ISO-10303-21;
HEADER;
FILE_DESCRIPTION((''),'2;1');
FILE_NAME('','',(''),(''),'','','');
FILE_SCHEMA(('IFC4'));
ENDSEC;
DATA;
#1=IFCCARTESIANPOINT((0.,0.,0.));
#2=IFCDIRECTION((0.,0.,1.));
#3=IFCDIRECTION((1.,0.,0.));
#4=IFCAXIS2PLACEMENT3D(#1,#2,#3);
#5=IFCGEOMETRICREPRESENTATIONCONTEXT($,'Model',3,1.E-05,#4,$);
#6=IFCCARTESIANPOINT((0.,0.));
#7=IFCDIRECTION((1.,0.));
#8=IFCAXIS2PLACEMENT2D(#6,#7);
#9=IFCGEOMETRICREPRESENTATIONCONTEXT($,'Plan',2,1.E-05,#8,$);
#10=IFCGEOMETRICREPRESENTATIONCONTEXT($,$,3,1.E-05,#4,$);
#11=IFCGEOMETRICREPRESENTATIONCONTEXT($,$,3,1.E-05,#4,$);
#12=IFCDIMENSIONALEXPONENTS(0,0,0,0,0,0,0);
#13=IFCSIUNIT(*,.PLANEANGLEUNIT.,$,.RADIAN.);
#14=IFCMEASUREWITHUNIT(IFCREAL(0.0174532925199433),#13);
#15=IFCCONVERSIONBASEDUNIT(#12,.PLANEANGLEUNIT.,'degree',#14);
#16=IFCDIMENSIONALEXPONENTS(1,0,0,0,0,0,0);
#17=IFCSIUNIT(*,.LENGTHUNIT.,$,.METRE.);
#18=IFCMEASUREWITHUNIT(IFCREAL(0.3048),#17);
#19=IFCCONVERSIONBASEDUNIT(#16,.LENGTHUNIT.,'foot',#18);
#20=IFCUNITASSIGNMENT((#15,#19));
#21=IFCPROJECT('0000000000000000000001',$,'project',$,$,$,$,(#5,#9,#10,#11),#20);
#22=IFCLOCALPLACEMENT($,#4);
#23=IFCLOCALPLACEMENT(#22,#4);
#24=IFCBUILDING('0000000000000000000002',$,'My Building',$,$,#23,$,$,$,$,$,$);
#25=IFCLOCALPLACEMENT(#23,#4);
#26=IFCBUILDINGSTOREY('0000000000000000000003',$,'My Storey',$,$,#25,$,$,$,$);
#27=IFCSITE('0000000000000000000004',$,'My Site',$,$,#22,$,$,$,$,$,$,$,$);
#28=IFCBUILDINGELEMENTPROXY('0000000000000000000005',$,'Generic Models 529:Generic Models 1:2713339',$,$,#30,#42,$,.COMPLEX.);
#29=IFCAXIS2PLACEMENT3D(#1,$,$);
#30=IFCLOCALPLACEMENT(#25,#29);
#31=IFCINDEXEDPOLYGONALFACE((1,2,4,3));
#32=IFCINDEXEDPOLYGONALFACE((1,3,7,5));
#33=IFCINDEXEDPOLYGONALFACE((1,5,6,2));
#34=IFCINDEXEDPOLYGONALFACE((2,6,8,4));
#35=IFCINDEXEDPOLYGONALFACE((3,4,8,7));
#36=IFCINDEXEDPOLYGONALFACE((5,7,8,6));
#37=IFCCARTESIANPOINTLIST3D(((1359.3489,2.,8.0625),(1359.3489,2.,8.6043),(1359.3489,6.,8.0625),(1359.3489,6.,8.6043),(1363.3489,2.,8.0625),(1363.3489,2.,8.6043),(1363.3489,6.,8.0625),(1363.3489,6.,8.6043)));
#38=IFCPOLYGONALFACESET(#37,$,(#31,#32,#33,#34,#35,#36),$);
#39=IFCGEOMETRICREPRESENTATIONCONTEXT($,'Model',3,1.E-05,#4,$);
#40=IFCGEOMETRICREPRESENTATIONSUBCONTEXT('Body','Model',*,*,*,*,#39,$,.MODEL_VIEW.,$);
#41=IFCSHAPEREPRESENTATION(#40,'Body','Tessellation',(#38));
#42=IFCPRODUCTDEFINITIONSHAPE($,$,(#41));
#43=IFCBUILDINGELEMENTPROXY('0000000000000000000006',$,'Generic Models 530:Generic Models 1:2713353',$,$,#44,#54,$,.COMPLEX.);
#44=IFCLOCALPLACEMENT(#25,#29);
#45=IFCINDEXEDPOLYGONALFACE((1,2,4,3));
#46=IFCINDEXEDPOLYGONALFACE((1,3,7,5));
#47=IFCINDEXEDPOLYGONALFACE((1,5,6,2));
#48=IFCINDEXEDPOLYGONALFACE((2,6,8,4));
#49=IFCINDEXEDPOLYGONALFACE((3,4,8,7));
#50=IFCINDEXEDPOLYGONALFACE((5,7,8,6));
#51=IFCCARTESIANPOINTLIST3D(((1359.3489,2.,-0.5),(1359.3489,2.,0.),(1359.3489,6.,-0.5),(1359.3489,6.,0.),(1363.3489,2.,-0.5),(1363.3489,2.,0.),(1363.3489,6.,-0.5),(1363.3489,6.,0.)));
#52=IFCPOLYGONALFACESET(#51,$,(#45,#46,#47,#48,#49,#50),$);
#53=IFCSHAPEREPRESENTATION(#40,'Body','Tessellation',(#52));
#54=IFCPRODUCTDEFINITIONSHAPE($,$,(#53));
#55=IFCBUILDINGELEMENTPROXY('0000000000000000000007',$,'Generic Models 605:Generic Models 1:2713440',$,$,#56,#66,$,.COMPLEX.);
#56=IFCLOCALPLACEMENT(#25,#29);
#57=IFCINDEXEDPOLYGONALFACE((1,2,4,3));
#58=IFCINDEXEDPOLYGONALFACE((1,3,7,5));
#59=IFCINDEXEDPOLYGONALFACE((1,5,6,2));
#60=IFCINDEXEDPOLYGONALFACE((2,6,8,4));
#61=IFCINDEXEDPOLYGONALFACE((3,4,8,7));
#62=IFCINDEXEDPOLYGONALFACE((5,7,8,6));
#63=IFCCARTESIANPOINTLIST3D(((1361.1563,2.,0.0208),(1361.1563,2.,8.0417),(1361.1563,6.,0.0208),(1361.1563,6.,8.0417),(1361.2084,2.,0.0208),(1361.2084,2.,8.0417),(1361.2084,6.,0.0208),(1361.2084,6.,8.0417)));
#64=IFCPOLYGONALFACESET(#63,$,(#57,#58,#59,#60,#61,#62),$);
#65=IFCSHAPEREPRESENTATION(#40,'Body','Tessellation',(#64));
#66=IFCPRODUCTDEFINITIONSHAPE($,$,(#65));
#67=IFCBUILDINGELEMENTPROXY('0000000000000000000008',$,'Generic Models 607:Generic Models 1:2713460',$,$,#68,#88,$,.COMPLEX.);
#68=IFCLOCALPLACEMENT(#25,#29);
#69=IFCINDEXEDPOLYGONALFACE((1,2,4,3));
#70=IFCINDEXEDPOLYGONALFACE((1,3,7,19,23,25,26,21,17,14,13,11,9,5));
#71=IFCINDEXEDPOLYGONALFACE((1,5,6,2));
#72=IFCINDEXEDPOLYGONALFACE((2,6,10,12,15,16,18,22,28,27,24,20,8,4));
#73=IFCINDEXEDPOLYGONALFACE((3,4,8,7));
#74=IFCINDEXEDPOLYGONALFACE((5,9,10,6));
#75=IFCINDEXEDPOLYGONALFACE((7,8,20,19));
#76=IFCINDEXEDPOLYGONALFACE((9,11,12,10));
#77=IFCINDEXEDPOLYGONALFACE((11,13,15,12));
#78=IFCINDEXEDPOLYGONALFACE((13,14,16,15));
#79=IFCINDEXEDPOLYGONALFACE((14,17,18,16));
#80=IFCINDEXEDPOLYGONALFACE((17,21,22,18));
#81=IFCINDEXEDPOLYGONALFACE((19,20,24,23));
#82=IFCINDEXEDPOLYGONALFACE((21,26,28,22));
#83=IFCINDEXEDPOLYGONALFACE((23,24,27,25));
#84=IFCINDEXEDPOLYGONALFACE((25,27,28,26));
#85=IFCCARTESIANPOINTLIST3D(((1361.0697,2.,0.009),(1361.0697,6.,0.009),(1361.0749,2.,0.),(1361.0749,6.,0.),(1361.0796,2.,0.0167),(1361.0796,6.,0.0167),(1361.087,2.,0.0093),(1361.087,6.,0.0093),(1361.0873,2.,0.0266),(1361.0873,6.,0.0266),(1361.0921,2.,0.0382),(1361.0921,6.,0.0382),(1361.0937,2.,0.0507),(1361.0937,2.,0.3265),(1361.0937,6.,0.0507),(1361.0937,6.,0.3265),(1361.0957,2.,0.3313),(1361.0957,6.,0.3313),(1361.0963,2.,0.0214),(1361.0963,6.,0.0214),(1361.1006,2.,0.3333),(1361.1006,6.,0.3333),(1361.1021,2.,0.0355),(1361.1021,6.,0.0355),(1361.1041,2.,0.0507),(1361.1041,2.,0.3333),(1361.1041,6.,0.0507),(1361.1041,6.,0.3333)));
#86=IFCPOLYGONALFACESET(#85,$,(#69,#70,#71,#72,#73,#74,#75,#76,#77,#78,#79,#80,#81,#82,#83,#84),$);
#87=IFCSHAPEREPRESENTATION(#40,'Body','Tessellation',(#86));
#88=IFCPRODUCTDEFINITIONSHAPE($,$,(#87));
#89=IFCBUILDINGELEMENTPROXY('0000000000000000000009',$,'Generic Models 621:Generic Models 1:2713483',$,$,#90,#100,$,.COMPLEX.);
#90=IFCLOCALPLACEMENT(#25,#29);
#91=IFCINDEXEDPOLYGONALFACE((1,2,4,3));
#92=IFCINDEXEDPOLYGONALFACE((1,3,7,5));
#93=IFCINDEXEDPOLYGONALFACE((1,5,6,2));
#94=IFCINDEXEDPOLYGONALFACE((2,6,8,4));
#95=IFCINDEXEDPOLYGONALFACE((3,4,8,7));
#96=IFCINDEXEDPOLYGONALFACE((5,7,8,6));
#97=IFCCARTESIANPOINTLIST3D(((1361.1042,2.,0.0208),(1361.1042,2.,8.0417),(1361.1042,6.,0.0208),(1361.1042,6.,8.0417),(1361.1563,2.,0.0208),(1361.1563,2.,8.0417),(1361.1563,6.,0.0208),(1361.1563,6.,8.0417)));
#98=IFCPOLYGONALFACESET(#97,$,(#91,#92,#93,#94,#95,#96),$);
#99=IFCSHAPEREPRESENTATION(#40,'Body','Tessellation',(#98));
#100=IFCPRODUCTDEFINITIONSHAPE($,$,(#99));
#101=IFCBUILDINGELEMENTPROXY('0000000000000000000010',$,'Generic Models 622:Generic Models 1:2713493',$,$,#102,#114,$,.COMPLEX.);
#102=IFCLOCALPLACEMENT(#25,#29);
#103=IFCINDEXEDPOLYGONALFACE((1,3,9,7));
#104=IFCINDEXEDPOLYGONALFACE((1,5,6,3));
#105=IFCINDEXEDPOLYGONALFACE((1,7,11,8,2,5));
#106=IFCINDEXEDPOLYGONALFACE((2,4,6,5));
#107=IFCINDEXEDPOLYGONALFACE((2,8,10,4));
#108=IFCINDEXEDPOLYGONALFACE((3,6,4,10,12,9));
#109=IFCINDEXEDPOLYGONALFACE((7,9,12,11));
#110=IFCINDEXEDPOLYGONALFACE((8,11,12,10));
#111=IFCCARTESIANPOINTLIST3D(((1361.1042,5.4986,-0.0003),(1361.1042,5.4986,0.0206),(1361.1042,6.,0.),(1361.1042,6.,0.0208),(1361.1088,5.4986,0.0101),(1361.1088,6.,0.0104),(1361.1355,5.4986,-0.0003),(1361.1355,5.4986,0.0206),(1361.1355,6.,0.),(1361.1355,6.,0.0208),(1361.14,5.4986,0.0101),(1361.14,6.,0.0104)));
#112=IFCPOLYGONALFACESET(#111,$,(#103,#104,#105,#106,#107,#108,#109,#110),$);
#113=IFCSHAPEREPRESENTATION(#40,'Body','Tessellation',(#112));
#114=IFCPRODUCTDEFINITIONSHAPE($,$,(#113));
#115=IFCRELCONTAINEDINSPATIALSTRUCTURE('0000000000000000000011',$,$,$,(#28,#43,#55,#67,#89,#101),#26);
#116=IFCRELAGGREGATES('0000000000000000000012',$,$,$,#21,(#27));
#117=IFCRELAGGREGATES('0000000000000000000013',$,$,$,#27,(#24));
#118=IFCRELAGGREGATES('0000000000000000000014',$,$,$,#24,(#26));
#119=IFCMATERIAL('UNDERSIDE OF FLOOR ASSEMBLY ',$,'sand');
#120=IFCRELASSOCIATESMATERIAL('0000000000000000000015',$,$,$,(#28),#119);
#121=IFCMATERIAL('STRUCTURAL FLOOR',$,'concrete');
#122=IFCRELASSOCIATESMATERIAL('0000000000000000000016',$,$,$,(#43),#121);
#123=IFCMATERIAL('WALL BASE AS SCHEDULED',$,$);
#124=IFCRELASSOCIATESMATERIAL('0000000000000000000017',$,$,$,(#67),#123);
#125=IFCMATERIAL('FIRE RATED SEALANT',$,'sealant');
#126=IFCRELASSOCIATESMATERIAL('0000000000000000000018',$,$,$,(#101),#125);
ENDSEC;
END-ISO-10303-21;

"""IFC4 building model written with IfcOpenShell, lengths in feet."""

from ifc_helpers import new_model, entity, si_unit, converted_unit, frame, origin_with_axes, origin_2d_with_axis, place, context, subcontext, project, spatial, polyline, outline, extrude, material, element, save


model = new_model("IFC4")

# Units and contexts
model_context_1 = context("Model", 3, precision=1e-05, world=origin_with_axes())
plan_context = context("Plan", 2, precision=1e-05, world=origin_2d_with_axis())
model_context_2 = context("Model", 3, precision=1e-05, world=origin_with_axes())
context_of_model_1 = context(None, 3, precision=1e-05, world=origin_with_axes())
context_of_model_2 = context(None, 3, precision=1e-05, world=origin_with_axes())
body_context_1 = subcontext(model_context_2, "Body", "Model", "MODEL_VIEW")
ifc_project = project(units=[converted_unit("PLANEANGLEUNIT", "degree", entity("IfcReal", 0.0174532925199433), si_unit("PLANEANGLEUNIT", "RADIAN"), dimensions=[0, 0, 0, 0, 0, 0, 0]), converted_unit("LENGTHUNIT", "foot", entity("IfcReal", 0.3048), si_unit("LENGTHUNIT", "METRE"), dimensions=[1, 0, 0, 0, 0, 0, 0])], contexts=[model_context_1, plan_context, context_of_model_1, context_of_model_2])

# Site, building, storey
site_placement = place(None, origin_with_axes())
site = spatial("IfcSite", under=ifc_project, at=site_placement, Name="My Site")
building_placement = place(site_placement, origin_with_axes())
building = spatial("IfcBuilding", under=site, at=building_placement, Name="My Building")
storey_placement = place(building_placement, origin_with_axes())
storey = spatial("IfcBuildingStorey", under=building, at=storey_placement, Name="My Storey")

# Building element proxies
ifc_material_1 = material(Name="UNDERSIDE OF FLOOR ASSEMBLY ", Category="sand")
proxy_1_placement = place(storey_placement, frame((1359.3489, 6.0, 8.0625), z_axis=(0.0, -1.0, 0.0), x_axis=(0.0, 0.0, 1.0)))
element("IfcBuildingElementProxy", 1, at=proxy_1_placement, inside=storey, material=ifc_material_1, Name="Generic Models 529:Generic Models 1:2713339", PredefinedType="COMPLEX", context=body_context_1, shape_type="SweptSolid", body=[
    extrude(outline(polyline([(-0.2709, -2.0), (0.2709, -2.0), (0.2709, 2.0), (-0.2709, 2.0), (-0.2709, -2.0)])), frame((0.2709, -2.0, 0.0), z_axis=(0.0, 0.0, -1.0), x_axis=(1.0, 0.0, 0.0)), (0.0, 0.0, -1.0), 4.0),
])
ifc_material_2 = material(Name="STRUCTURAL FLOOR", Category="concrete")
proxy_2_placement = place(storey_placement, frame((1359.3489, 6.0, -0.5), z_axis=(0.0, -1.0, 0.0), x_axis=(0.0, 0.0, 1.0)))
element("IfcBuildingElementProxy", 2, at=proxy_2_placement, inside=storey, material=ifc_material_2, Name="Generic Models 530:Generic Models 1:2713353", PredefinedType="COMPLEX", context=body_context_1, shape_type="SweptSolid", body=[
    extrude(outline(polyline([(-0.25, -2.0), (0.25, -2.0), (0.25, 2.0), (-0.25, 2.0), (-0.25, -2.0)])), frame((0.25, -2.0, 0.0), z_axis=(0.0, 0.0, -1.0), x_axis=(1.0, 0.0, 0.0)), (0.0, 0.0, -1.0), 4.0),
])
proxy_3_placement = place(storey_placement, frame((1361.1563, 6.0, 0.0208), z_axis=(0.0, -1.0, 0.0), x_axis=(0.0, 0.0, 1.0)))
element("IfcBuildingElementProxy", 3, at=proxy_3_placement, inside=storey, Name="Generic Models 605:Generic Models 1:2713440", PredefinedType="COMPLEX", context=body_context_1, shape_type="SweptSolid", body=[
    extrude(outline(polyline([(-0.026, -4.0104), (0.026, -4.0104), (0.026, 4.0104), (-0.026, 4.0104), (-0.026, -4.0104)])), frame((4.0104, -0.026, 0.0), z_axis=(0.0, 0.0, -1.0), x_axis=(0.0, 1.0, 0.0)), (0.0, 0.0, -1.0), 4.0),
])
ifc_material_3 = material(Name="WALL BASE AS SCHEDULED")
proxy_4_placement = place(storey_placement, frame((1361.0697, 6.0, 0.0), z_axis=(0.0, -1.0, 0.0), x_axis=(0.0, 0.0, 1.0)))
element("IfcBuildingElementProxy", 4, at=proxy_4_placement, inside=storey, material=ifc_material_3, Name="Generic Models 607:Generic Models 1:2713460", PredefinedType="COMPLEX", context=body_context_1, shape_type="SweptSolid", body=[
    extrude(outline(polyline([(0.2205, 0.0), (0.2206, 0.0036), (-0.0618, 0.0152), (-0.077, 0.0138), (-0.0914, 0.0086), (-0.1038, -0.0002), (-0.1136, -0.012), (-0.1048, -0.0175), (-0.0968, -0.0079), (-0.0865, -0.0007), (-0.0747, 0.0037), (-0.0622, 0.0048), (0.2133, -0.0066), (0.2183, -0.0048), (0.2205, 0.0)])), frame((0.113, -0.0218, 0.0), z_axis=(0.0, 0.0, -1.0), x_axis=(0.999153, -0.041137, 0.0)), (0.0, 0.0, -1.0), 4.0),
])
ifc_material_4 = material(Name="FIRE RATED SEALANT", Category="sealant")
proxy_5_placement = place(storey_placement, frame((1361.1042, 6.0, 0.0208), z_axis=(0.0, -1.0, 0.0), x_axis=(0.0, 0.0, 1.0)))
element("IfcBuildingElementProxy", 5, at=proxy_5_placement, inside=storey, Name="Generic Models 621:Generic Models 1:2713483", PredefinedType="COMPLEX", context=body_context_1, shape_type="SweptSolid", body=[
    extrude(outline(polyline([(-4.0104, -0.026), (4.0104, -0.026), (4.0104, 0.026), (-4.0104, 0.026), (-4.0104, -0.026)])), frame((4.0104, -0.026, 0.0), z_axis=(0.0, 0.0, -1.0), x_axis=(1.0, 0.0, 0.0)), (0.0, 0.0, -1.0), 4.0),
])
proxy_6_placement = place(storey_placement, frame((1361.1042, 6.0, 0.0), z_axis=(0.0, -1.0, 0.0), x_axis=(0.0, 0.0, 1.0)))
element("IfcBuildingElementProxy", 6, at=proxy_6_placement, inside=storey, material=ifc_material_4, Name="Generic Models 622:Generic Models 1:2713493", PredefinedType="COMPLEX", context=body_context_1, shape_type="SweptSolid", body=[
    extrude(outline(polyline([(0.0201, 0.0), (-0.0066, 0.0162), (-0.016, 0.0097), (-0.0175, -0.0016), (0.0093, -0.0178), (0.0107, -0.0065), (0.0201, 0.0)])), frame((0.0104, -0.0172, 0.0), z_axis=(0.0, 0.0, -1.0), x_axis=(0.51911, 0.854708, 0.0)), (-0.000285, -0.000479, -1.0), 0.5014),
])

save(model, "model.ifc")
